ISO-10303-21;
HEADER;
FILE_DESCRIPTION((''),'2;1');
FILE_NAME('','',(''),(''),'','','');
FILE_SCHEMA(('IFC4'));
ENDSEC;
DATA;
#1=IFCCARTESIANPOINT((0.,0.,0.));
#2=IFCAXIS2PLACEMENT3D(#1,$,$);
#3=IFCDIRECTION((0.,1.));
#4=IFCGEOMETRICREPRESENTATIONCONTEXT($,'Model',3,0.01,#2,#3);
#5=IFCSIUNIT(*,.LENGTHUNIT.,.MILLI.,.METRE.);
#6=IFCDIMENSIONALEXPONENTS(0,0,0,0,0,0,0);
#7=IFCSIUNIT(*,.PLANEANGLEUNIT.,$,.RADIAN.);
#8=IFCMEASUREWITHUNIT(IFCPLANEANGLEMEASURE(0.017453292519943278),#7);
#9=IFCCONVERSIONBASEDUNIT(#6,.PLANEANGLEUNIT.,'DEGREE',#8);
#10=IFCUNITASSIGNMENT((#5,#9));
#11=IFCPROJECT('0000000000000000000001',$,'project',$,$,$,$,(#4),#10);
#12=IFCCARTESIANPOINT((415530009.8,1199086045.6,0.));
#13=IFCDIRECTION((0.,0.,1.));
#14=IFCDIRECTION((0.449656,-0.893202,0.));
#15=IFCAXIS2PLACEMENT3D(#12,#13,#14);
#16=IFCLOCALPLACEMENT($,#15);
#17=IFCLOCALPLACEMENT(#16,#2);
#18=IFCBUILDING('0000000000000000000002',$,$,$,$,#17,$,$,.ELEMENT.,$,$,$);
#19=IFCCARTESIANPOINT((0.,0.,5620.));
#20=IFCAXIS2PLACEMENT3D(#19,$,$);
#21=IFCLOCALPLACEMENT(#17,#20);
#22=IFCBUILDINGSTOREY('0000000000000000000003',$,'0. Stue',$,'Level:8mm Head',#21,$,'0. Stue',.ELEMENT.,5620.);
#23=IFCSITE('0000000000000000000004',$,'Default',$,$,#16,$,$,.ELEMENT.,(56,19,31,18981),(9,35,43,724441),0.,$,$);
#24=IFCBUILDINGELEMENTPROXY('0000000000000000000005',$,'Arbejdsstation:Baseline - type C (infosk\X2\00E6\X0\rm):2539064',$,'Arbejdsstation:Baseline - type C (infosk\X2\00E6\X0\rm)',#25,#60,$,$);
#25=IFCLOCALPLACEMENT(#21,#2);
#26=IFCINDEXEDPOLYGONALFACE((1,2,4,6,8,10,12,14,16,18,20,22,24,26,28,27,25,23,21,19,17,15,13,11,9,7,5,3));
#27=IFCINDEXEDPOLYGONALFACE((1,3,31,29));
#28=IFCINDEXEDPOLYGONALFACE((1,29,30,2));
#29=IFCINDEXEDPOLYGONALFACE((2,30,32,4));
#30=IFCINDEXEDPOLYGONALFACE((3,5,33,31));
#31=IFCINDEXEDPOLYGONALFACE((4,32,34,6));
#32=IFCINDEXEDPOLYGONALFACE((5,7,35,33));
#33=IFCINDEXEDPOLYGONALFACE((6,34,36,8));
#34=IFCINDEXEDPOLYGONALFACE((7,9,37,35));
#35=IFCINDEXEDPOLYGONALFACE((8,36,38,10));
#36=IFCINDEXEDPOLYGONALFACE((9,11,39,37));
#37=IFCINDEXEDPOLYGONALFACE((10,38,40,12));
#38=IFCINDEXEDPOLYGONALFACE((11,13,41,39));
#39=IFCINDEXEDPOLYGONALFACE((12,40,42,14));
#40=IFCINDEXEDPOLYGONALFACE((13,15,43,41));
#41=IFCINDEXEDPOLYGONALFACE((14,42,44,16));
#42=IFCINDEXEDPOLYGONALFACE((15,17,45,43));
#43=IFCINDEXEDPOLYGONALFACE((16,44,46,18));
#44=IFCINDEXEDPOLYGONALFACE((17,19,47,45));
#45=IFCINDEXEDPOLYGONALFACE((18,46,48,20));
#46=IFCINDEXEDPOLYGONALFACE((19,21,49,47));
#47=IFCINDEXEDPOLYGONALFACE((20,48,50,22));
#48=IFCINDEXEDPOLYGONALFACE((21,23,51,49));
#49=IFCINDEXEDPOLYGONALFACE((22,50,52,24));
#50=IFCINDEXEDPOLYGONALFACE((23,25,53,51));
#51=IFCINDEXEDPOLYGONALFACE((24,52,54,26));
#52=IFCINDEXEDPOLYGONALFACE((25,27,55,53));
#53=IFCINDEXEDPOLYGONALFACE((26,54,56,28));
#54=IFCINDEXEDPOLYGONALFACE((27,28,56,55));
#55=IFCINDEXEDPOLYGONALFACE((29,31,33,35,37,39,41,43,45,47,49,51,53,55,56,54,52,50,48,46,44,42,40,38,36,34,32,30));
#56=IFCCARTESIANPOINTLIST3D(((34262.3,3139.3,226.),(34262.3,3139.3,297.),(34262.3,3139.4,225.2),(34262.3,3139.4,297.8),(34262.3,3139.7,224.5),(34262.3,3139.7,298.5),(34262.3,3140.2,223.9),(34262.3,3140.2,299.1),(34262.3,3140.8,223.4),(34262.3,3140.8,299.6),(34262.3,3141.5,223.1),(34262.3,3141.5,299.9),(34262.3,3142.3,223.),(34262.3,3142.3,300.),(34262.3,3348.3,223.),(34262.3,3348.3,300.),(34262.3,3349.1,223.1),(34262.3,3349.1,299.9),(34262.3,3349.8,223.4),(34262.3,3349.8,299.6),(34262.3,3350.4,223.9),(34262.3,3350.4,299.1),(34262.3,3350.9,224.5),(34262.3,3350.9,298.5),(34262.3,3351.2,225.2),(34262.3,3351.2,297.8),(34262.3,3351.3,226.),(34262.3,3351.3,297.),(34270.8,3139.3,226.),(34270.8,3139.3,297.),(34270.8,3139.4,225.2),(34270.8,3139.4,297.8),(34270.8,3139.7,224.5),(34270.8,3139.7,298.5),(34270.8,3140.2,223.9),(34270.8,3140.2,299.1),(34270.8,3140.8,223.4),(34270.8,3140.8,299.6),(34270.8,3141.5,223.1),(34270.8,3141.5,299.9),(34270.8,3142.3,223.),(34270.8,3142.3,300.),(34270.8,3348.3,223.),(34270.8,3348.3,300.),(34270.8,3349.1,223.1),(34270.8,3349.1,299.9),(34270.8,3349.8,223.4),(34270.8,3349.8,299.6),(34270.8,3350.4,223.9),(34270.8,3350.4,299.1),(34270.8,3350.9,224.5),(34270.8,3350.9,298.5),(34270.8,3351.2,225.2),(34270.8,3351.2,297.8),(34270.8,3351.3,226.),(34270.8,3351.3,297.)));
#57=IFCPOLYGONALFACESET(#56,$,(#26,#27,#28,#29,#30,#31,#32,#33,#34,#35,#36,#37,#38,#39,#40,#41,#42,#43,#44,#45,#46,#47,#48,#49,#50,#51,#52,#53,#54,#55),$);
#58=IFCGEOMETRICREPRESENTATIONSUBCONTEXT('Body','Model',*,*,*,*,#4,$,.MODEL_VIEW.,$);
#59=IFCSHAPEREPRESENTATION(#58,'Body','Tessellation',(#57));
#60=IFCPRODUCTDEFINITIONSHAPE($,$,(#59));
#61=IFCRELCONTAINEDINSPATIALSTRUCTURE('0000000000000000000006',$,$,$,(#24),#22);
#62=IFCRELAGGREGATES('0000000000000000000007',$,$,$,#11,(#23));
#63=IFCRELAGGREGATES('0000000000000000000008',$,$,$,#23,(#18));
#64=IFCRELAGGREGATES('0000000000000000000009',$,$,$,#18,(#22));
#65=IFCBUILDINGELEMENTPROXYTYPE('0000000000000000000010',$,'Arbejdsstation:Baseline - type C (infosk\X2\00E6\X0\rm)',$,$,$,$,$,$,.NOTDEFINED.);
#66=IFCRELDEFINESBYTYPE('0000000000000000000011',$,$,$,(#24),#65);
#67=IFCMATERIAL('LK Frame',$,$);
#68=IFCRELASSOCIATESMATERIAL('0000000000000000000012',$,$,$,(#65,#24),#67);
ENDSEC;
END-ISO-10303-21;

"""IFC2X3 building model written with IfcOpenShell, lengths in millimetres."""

from ifc_helpers import new_model, entity, si_unit, converted_unit, direction, frame, frame_2d, origin, place, context, subcontext, project, spatial, polyline, circle_curve, parameter, trimmed, segment, composite_curve, outline, extrude, source, transform, mapped, material, type_object, type_shapes, element, save


model = new_model("IFC2X3")

# Units and contexts
model_context = context("Model", 3, precision=0.01, world=origin(), true_north=direction((0.0, 1.0)))
body_context = subcontext(model_context, "Body", "Model", "MODEL_VIEW")
ifc_project = project(units=[si_unit("LENGTHUNIT", "METRE", prefix="MILLI"), converted_unit("PLANEANGLEUNIT", "DEGREE", entity("IfcPlaneAngleMeasure", 0.017453292519943278), si_unit("PLANEANGLEUNIT", "RADIAN"), dimensions=[0, 0, 0, 0, 0, 0, 0])], contexts=[model_context])

# Site, building, storey
site_placement = place(None, frame((415530009.8, 1199086045.6, 0.0), z_axis=(0.0, 0.0, 1.0), x_axis=(0.449656, -0.893202, 0.0)))
site = spatial("IfcSite", under=ifc_project, at=site_placement, Name="Default", CompositionType="ELEMENT", RefLatitude=(56, 19, 31, 18981), RefLongitude=(9, 35, 43, 724441), RefElevation=0.0)
building_placement = place(site_placement, origin())
building = spatial("IfcBuilding", under=site, at=building_placement, CompositionType="ELEMENT")
storey_placement = place(building_placement, frame((0.0, 0.0, 5620.0)))
storey = spatial("IfcBuildingStorey", under=building, at=storey_placement, Name="0. Stue", ObjectType="Level:8mm Head", LongName="0. Stue", CompositionType="ELEMENT", Elevation=5620.0)

# Building element proxy
ifc_material_1 = material(Name="LK Frame")
building_element_proxy_type_1 = type_object("IfcBuildingElementProxyType", Name="Arbejdsstation:Baseline - type C (infoskærm)", PredefinedType="NOTDEFINED", material=ifc_material_1)
shared_shape_1 = source(origin(), body_context, "Body", "SweptSolid", [
    extrude(outline(composite_curve([segment(polyline([(-35.5, -106.0), (35.5, -106.0)]), True, "CONTINUOUS"), segment(trimmed(circle_curve(frame_2d((35.5, -103.0), x_axis=(-1.0, 0.0)), 3.0), [parameter(90.0)], [parameter(180.0)], True, "PARAMETER"), True, "CONTINUOUS"), segment(polyline([(38.5, -103.0), (38.5, 103.0)]), True, "CONTINUOUS"), segment(trimmed(circle_curve(frame_2d((35.5, 103.0), x_axis=(-1.0, 0.0)), 3.0), [parameter(180.0)], [parameter(270.0)], True, "PARAMETER"), True, "CONTINUOUS"), segment(polyline([(35.5, 106.0), (-35.5, 106.0)]), True, "CONTINUOUS"), segment(trimmed(circle_curve(frame_2d((-35.5, 103.0), x_axis=(1.0, 0.0)), 3.0), [parameter(90.0)], [parameter(180.0)], True, "PARAMETER"), True, "CONTINUOUS"), segment(polyline([(-38.5, 103.0), (-38.5, -103.0)]), True, "CONTINUOUS"), segment(trimmed(circle_curve(frame_2d((-35.5, -103.0), x_axis=(1.0, 0.0)), 3.0), [parameter(180.0)], [parameter(270.0)], True, "PARAMETER"), True, "CONTINUOUS")], self_intersect=False)), frame((-3.5, -38.5, 0.0), z_axis=(0.0, 0.0, 1.0), x_axis=(0.0, 1.0, 0.0)), (0.0, 0.0, 1.0), 8.5),
])
type_shapes(building_element_proxy_type_1, [shared_shape_1])
proxy_1_placement = place(storey_placement, frame((34270.8, 3241.8, 300.0), z_axis=(-1.0, 0.0, 0.0), x_axis=(0.0, -1.0, 0.0)))
element("IfcBuildingElementProxy", 1, at=proxy_1_placement, inside=storey, type_object=building_element_proxy_type_1, material=ifc_material_1, Name="Arbejdsstation:Baseline - type C (infoskærm):2539064", ObjectType="Arbejdsstation:Baseline - type C (infoskærm)", context=body_context, shape_type="MappedRepresentation", body=[
    mapped(shared_shape_1, transform((0.0, 0.0, 0.0), scale=1.0)),
])

save(model, "model.ifc")
